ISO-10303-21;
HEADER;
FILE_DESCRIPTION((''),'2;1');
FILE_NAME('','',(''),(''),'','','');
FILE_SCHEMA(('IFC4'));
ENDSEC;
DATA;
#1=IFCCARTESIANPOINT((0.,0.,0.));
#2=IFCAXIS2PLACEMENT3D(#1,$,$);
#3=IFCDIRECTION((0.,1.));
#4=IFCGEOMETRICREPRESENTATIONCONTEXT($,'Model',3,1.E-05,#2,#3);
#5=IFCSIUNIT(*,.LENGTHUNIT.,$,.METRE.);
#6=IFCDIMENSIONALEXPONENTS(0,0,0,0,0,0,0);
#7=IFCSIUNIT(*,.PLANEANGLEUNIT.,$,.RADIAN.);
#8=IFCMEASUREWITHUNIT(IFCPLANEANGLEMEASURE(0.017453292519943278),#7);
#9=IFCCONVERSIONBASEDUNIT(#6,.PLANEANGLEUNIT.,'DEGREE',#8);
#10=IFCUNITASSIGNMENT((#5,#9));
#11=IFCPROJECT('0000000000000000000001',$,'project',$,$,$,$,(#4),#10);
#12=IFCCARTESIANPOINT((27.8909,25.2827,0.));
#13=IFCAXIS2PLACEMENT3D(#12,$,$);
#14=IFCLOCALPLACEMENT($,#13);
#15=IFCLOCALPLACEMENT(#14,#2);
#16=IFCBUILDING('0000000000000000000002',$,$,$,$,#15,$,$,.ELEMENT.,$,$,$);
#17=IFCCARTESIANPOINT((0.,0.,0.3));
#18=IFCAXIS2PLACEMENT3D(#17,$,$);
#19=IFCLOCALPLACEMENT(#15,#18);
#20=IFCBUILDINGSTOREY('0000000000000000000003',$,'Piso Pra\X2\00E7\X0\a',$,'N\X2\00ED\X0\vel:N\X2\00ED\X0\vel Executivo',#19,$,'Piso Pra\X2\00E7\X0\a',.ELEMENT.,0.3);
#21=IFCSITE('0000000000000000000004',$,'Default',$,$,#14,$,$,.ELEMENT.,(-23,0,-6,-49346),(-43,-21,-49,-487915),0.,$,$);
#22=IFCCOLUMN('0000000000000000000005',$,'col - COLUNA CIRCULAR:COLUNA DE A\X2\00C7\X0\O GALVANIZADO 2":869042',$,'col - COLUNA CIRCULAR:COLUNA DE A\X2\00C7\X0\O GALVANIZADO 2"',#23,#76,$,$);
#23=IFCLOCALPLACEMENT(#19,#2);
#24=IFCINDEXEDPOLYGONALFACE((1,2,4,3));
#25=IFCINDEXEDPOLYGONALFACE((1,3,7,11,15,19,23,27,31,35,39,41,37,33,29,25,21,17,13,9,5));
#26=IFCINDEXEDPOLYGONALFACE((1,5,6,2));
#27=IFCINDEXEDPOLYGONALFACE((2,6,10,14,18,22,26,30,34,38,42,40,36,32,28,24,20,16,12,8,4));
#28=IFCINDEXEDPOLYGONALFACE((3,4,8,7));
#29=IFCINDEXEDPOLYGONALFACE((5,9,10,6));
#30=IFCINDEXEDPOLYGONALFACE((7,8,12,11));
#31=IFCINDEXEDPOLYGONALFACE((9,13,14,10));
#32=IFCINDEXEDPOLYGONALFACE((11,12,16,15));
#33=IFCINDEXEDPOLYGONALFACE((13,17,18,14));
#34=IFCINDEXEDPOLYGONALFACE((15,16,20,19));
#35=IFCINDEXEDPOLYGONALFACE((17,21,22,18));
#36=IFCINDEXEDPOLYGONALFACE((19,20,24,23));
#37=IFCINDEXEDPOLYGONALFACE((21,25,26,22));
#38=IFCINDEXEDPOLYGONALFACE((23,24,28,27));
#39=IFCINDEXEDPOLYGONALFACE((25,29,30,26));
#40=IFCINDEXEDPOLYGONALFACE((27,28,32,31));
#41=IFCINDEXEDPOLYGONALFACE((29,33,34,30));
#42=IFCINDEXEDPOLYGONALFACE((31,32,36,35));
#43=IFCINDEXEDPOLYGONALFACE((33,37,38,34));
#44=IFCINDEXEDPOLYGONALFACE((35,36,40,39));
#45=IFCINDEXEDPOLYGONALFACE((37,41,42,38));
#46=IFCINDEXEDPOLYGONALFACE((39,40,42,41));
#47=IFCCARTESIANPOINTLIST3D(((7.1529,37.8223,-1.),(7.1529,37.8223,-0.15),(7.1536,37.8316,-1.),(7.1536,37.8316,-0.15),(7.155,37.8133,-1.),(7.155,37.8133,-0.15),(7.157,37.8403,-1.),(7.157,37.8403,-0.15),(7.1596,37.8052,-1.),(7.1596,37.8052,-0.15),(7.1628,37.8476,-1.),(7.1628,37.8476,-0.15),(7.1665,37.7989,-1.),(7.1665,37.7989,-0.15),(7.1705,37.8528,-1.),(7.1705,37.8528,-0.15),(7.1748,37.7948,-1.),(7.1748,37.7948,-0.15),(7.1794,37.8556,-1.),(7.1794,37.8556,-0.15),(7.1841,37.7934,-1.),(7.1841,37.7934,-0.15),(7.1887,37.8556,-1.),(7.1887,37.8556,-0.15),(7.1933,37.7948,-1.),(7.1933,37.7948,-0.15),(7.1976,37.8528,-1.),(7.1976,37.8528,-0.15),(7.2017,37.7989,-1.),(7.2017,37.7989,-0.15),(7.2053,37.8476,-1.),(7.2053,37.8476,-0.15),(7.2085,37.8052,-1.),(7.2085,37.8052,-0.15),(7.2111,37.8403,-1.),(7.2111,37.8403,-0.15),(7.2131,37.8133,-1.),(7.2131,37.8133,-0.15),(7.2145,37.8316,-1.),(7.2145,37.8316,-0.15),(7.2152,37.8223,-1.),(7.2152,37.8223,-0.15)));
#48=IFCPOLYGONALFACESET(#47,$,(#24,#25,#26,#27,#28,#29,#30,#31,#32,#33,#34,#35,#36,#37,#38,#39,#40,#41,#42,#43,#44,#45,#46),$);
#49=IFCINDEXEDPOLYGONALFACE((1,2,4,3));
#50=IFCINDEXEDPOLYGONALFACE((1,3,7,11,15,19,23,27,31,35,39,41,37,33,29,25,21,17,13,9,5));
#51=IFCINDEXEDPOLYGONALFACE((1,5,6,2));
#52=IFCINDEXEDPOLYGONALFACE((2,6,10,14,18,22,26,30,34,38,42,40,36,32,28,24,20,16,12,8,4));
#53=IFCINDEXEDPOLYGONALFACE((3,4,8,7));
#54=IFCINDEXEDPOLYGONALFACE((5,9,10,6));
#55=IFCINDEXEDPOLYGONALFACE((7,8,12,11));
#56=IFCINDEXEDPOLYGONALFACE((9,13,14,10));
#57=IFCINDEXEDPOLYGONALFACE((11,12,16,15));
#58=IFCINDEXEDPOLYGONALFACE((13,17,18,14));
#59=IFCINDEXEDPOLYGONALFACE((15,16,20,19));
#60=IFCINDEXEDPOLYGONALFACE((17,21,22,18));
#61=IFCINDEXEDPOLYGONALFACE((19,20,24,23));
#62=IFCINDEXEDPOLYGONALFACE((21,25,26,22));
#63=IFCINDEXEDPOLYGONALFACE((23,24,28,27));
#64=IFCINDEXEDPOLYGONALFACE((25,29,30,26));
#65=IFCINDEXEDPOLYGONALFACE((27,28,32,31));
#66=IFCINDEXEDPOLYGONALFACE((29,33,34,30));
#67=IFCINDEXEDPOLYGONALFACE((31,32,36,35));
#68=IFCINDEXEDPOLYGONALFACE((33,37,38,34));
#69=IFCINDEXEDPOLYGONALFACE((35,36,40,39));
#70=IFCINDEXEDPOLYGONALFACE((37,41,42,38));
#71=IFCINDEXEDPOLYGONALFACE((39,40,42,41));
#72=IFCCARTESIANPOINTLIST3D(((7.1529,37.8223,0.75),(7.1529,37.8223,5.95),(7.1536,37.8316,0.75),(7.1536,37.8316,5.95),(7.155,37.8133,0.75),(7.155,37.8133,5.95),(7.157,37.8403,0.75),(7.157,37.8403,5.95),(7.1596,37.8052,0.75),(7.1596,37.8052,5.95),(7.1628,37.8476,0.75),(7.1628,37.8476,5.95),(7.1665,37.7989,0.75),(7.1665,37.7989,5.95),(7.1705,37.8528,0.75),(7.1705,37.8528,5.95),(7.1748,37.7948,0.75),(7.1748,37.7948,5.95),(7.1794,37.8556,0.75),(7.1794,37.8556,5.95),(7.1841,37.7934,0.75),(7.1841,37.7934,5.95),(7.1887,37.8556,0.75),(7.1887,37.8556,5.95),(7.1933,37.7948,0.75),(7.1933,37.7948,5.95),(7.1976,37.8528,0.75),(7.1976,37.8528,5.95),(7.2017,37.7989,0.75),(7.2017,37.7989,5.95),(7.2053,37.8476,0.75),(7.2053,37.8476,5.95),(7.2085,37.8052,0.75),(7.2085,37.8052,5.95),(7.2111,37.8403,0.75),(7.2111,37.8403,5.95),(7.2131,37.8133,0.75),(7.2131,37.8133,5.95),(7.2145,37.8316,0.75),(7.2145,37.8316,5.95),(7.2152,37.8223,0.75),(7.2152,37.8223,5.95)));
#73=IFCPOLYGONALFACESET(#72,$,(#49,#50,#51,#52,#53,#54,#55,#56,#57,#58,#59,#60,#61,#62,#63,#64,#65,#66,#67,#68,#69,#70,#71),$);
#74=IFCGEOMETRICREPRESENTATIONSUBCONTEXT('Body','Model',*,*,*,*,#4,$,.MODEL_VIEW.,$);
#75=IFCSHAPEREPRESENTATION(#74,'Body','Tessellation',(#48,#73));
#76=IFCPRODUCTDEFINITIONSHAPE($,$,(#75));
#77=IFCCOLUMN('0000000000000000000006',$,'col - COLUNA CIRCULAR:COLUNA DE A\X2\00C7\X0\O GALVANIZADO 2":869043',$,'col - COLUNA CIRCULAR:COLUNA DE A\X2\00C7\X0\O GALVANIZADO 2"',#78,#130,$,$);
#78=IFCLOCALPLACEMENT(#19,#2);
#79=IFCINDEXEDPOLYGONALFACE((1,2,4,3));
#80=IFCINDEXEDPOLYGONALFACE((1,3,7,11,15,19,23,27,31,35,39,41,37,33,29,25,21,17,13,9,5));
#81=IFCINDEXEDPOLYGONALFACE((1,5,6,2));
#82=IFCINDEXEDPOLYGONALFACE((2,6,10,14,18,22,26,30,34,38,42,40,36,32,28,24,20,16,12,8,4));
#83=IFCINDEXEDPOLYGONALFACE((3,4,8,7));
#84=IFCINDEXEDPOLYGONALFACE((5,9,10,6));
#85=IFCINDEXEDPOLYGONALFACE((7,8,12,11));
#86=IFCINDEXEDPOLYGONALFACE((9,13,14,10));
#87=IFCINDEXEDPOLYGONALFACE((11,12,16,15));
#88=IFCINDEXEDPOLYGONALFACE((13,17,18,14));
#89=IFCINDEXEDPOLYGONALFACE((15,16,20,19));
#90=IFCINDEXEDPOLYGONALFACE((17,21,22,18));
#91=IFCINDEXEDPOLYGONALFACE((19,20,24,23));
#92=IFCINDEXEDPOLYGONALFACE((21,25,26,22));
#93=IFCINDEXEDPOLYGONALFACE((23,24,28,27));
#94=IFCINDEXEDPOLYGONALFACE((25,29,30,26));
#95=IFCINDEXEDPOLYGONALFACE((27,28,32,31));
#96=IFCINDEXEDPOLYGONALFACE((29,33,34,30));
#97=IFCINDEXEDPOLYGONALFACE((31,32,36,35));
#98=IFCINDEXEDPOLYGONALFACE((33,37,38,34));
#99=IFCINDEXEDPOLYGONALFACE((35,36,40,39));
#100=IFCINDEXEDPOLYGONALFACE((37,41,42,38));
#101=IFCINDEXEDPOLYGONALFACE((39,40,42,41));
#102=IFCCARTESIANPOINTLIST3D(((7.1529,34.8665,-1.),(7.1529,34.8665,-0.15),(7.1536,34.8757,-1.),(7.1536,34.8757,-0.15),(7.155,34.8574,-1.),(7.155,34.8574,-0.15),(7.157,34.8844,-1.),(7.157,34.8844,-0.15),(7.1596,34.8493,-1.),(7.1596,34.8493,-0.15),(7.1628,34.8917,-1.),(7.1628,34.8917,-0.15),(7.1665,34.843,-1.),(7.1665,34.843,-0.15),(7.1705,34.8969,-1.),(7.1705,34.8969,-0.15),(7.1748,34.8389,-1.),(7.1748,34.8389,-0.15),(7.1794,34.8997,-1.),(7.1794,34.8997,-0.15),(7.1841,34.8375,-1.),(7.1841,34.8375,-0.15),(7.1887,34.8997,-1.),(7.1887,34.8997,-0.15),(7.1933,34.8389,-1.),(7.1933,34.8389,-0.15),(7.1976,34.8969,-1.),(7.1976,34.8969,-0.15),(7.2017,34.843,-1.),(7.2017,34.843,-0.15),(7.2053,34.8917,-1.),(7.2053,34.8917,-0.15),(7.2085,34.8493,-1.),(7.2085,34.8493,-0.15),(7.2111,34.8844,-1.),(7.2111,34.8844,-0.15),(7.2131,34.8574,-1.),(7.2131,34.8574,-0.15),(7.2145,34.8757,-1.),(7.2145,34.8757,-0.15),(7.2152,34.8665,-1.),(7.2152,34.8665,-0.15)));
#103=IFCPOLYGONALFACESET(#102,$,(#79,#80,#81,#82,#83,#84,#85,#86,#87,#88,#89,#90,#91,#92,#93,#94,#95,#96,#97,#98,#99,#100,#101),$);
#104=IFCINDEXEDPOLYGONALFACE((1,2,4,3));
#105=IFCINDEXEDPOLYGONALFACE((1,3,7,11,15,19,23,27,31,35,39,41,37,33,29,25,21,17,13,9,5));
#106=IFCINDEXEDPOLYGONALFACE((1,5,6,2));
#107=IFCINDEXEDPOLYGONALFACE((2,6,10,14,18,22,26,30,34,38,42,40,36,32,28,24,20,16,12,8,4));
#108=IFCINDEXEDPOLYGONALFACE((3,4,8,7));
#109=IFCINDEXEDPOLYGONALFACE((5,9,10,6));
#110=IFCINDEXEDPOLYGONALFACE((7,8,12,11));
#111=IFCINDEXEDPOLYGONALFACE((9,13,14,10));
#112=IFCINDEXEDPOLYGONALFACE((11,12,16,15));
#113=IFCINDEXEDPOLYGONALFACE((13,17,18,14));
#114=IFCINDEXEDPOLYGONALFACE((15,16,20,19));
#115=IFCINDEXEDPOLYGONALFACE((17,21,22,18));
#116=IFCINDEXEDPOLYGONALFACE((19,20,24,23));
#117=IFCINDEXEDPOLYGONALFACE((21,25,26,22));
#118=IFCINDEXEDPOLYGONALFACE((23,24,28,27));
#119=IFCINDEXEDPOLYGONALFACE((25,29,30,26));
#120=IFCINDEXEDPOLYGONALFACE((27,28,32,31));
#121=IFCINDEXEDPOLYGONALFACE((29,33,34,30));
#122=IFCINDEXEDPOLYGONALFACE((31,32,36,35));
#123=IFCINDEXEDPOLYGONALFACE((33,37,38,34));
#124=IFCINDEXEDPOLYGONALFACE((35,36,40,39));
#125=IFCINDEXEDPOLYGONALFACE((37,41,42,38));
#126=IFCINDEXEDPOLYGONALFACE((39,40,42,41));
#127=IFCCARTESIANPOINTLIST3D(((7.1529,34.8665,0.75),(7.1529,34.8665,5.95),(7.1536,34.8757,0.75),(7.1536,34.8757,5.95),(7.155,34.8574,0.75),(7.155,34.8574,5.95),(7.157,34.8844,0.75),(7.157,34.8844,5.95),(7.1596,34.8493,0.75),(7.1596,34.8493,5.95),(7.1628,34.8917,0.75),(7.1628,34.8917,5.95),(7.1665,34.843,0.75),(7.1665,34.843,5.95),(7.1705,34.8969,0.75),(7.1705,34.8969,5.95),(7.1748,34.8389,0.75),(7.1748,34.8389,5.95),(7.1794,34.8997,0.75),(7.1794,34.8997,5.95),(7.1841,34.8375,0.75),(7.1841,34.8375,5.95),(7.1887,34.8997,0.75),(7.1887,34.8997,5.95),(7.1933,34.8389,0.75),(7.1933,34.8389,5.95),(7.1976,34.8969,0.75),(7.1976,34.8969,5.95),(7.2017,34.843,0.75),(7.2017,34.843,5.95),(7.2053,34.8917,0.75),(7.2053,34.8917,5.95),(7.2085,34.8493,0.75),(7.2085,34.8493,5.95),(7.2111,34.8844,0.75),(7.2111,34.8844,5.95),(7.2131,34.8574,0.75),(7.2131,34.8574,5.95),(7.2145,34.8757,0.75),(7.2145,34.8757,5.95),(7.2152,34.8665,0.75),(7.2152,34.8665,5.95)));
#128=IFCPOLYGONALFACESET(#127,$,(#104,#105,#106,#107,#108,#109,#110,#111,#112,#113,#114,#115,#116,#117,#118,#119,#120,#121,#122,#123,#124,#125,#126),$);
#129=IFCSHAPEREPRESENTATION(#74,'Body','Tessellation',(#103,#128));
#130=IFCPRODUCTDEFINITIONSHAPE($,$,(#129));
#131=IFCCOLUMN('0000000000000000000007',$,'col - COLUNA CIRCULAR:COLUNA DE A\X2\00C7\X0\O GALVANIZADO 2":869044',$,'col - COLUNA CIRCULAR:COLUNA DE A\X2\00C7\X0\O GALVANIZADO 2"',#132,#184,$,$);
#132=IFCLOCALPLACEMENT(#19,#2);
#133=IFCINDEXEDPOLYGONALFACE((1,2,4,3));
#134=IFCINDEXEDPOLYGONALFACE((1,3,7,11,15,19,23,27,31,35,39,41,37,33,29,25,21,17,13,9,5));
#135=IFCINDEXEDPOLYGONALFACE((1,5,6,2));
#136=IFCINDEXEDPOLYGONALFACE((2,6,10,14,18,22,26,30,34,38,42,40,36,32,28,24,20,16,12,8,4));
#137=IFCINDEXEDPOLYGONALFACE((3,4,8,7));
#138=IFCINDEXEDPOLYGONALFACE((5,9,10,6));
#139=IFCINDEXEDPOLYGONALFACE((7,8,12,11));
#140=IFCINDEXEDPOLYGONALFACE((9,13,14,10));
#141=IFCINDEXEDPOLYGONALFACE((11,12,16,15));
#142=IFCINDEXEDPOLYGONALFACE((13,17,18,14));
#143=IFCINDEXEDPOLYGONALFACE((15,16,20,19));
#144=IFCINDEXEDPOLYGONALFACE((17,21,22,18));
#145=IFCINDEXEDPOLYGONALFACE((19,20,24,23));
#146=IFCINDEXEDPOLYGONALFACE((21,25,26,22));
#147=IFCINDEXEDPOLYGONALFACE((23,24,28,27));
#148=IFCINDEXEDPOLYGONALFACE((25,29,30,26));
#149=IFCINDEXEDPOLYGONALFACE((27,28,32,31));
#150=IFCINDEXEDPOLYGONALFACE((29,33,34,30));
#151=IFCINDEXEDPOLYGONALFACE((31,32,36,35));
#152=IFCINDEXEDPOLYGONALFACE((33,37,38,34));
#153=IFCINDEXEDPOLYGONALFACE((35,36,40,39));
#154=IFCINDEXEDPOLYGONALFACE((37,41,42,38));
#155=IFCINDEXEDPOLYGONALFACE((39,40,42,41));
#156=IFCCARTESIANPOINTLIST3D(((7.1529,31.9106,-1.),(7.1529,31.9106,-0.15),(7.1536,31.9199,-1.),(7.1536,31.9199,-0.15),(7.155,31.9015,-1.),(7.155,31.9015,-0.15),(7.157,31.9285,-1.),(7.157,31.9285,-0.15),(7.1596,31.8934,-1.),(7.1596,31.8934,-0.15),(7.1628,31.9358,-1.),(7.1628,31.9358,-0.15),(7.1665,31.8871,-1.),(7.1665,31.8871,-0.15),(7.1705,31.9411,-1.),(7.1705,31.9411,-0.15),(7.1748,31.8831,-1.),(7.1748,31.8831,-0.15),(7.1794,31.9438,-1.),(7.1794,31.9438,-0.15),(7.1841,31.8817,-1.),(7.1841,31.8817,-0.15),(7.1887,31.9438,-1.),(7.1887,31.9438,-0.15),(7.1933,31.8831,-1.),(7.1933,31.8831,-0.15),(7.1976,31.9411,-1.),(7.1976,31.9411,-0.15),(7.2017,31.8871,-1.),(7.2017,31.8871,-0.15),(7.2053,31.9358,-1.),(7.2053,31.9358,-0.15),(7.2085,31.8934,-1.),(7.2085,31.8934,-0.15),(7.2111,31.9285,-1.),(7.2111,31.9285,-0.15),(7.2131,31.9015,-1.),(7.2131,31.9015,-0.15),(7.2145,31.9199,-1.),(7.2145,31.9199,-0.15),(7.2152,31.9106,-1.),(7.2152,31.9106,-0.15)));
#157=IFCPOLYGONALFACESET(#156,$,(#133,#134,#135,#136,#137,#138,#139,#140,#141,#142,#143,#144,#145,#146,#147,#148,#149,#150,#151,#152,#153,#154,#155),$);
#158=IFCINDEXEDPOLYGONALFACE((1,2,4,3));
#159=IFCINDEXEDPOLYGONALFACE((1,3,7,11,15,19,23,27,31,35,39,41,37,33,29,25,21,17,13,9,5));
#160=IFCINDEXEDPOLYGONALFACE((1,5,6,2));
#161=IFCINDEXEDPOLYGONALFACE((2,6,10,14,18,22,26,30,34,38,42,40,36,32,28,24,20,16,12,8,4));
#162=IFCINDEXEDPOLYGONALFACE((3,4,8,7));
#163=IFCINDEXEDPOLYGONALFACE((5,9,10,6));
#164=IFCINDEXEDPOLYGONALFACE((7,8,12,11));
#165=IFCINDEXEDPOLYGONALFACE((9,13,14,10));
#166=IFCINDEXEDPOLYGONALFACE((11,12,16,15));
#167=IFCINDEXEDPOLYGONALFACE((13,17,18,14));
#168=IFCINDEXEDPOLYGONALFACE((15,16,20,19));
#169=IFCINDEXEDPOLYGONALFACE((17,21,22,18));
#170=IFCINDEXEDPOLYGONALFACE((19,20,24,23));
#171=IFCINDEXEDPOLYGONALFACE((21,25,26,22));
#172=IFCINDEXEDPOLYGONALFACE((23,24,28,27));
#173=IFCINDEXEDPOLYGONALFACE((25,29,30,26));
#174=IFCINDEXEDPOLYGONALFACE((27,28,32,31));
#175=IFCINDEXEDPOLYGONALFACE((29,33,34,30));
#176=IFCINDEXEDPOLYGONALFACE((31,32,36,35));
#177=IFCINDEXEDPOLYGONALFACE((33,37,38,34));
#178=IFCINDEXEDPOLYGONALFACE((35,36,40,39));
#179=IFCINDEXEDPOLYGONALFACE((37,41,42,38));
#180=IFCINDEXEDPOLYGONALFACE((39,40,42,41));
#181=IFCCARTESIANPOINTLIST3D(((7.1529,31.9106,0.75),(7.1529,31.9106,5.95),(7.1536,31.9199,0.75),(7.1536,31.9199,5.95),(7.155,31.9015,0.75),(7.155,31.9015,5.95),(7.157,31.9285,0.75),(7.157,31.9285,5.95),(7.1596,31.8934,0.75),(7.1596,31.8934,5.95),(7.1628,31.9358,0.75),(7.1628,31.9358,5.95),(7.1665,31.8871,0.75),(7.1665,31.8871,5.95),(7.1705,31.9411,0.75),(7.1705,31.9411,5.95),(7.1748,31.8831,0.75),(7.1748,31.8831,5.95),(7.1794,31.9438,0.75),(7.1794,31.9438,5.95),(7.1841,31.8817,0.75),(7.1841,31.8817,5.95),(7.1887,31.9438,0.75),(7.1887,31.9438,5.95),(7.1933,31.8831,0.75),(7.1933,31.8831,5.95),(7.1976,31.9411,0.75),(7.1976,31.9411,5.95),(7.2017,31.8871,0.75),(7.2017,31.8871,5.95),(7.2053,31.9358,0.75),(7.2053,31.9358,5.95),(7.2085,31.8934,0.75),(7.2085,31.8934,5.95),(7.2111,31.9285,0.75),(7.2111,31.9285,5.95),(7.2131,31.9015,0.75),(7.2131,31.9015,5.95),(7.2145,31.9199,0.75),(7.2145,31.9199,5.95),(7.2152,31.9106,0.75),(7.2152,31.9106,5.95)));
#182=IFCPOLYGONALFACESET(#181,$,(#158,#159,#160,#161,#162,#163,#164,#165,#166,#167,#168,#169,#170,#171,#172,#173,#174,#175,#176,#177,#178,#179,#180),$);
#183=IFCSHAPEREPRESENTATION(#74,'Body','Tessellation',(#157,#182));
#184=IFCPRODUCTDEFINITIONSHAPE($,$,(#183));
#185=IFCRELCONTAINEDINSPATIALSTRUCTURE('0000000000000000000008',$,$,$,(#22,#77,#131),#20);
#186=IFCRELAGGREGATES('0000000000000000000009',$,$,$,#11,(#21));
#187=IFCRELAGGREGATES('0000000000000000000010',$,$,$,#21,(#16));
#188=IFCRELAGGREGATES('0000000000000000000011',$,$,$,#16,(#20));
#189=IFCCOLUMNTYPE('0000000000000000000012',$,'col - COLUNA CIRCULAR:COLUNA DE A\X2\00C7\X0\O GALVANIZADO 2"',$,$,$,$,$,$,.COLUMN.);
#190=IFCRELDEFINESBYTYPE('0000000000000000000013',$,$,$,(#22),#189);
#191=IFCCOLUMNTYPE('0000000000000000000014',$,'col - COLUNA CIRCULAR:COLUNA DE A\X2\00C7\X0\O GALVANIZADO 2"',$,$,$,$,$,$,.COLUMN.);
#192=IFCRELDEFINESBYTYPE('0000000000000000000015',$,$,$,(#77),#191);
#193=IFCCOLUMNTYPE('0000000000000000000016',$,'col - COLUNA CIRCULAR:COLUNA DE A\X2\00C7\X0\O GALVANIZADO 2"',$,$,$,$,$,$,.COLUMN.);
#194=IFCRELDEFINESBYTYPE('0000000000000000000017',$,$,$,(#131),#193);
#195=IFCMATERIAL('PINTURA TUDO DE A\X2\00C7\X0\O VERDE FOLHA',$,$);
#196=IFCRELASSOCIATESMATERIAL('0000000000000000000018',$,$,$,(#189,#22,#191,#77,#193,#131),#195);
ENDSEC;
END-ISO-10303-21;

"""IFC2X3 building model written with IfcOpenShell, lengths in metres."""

from ifc_helpers import new_model, entity, si_unit, converted_unit, direction, frame, origin, origin_2d_with_axis, place, context, subcontext, project, spatial, circle, extrude, source, transform, mapped, material, type_object, type_shapes, element, save


model = new_model("IFC2X3")

# Units and contexts
model_context = context("Model", 3, precision=1e-05, world=origin(), true_north=direction((0.0, 1.0)))
body_context = subcontext(model_context, "Body", "Model", "MODEL_VIEW")
ifc_project = project(units=[si_unit("LENGTHUNIT", "METRE"), converted_unit("PLANEANGLEUNIT", "DEGREE", entity("IfcPlaneAngleMeasure", 0.017453292519943278), si_unit("PLANEANGLEUNIT", "RADIAN"), dimensions=[0, 0, 0, 0, 0, 0, 0])], contexts=[model_context])

# Site, building, storey
site_placement = place(None, frame((27.8909, 25.2827, 0.0)))
site = spatial("IfcSite", under=ifc_project, at=site_placement, Name="Default", CompositionType="ELEMENT", RefLatitude=(-23, 0, -6, -49346), RefLongitude=(-43, -21, -49, -487915), RefElevation=0.0)
building_placement = place(site_placement, origin())
building = spatial("IfcBuilding", under=site, at=building_placement, CompositionType="ELEMENT")
storey_placement = place(building_placement, frame((0.0, 0.0, 0.3)))
storey = spatial("IfcBuildingStorey", under=building, at=storey_placement, Name="Piso Praça", ObjectType="Nível:Nível Executivo", LongName="Piso Praça", CompositionType="ELEMENT", Elevation=0.3)

# Columns
ifc_material = material(Name="PINTURA TUDO DE AÇO VERDE FOLHA")
column_type_1 = type_object("IfcColumnType", Name="col - COLUNA CIRCULAR:COLUNA DE AÇO GALVANIZADO 2\"", PredefinedType="COLUMN", material=ifc_material)
shared_shape_1 = source(origin(), body_context, "Body", "SweptSolid", [
    extrude(circle(Radius=0.0312, at=origin_2d_with_axis()), frame((7.1841, 37.8247, -0.7), z_axis=(0.0, 0.0, 1.0), x_axis=(0.0, -1.0, 0.0)), (0.0, 0.0, 1.0), 0.85),
    extrude(circle(Radius=0.0312, at=origin_2d_with_axis()), frame((7.1841, 37.8247, 1.05), z_axis=(0.0, 0.0, 1.0), x_axis=(0.0, -1.0, 0.0)), (0.0, 0.0, 1.0), 5.2),
])
type_shapes(column_type_1, [shared_shape_1])
column_1_placement = place(storey_placement, frame((0.0, 0.0, -0.3)))
element("IfcColumn", 1, at=column_1_placement, inside=storey, type_object=column_type_1, material=ifc_material, Name="col - COLUNA CIRCULAR:COLUNA DE AÇO GALVANIZADO 2\":869042", ObjectType="col - COLUNA CIRCULAR:COLUNA DE AÇO GALVANIZADO 2\"", context=body_context, shape_type="MappedRepresentation", body=[
    mapped(shared_shape_1, transform((0.0, 0.0, 0.0), scale=1.0)),
])
column_type_2 = type_object("IfcColumnType", Name="col - COLUNA CIRCULAR:COLUNA DE AÇO GALVANIZADO 2\"", PredefinedType="COLUMN", material=ifc_material)
shared_shape_2 = source(origin(), body_context, "Body", "SweptSolid", [
    extrude(circle(Radius=0.0312, at=origin_2d_with_axis()), frame((7.1841, 34.8688, -0.7), z_axis=(0.0, 0.0, 1.0), x_axis=(0.0, -1.0, 0.0)), (0.0, 0.0, 1.0), 0.85),
    extrude(circle(Radius=0.0312, at=origin_2d_with_axis()), frame((7.1841, 34.8688, 1.05), z_axis=(0.0, 0.0, 1.0), x_axis=(0.0, -1.0, 0.0)), (0.0, 0.0, 1.0), 5.2),
])
type_shapes(column_type_2, [shared_shape_2])
column_2_placement = place(storey_placement, frame((0.0, 0.0, -0.3)))
element("IfcColumn", 2, at=column_2_placement, inside=storey, type_object=column_type_2, material=ifc_material, Name="col - COLUNA CIRCULAR:COLUNA DE AÇO GALVANIZADO 2\":869043", ObjectType="col - COLUNA CIRCULAR:COLUNA DE AÇO GALVANIZADO 2\"", context=body_context, shape_type="MappedRepresentation", body=[
    mapped(shared_shape_2, transform((0.0, 0.0, 0.0), scale=1.0)),
])
column_type_3 = type_object("IfcColumnType", Name="col - COLUNA CIRCULAR:COLUNA DE AÇO GALVANIZADO 2\"", PredefinedType="COLUMN", material=ifc_material)
shared_shape_3 = source(origin(), body_context, "Body", "SweptSolid", [
    extrude(circle(Radius=0.0312, at=origin_2d_with_axis()), frame((7.1841, 31.9129, -0.7), z_axis=(0.0, 0.0, 1.0), x_axis=(0.0, -1.0, 0.0)), (0.0, 0.0, 1.0), 0.85),
    extrude(circle(Radius=0.0312, at=origin_2d_with_axis()), frame((7.1841, 31.9129, 1.05), z_axis=(0.0, 0.0, 1.0), x_axis=(0.0, -1.0, 0.0)), (0.0, 0.0, 1.0), 5.2),
])
type_shapes(column_type_3, [shared_shape_3])
column_3_placement = place(storey_placement, frame((0.0, 0.0, -0.3)))
element("IfcColumn", 3, at=column_3_placement, inside=storey, type_object=column_type_3, material=ifc_material, Name="col - COLUNA CIRCULAR:COLUNA DE AÇO GALVANIZADO 2\":869044", ObjectType="col - COLUNA CIRCULAR:COLUNA DE AÇO GALVANIZADO 2\"", context=body_context, shape_type="MappedRepresentation", body=[
    mapped(shared_shape_3, transform((0.0, 0.0, 0.0), scale=1.0)),
])

save(model, "model.ifc")
